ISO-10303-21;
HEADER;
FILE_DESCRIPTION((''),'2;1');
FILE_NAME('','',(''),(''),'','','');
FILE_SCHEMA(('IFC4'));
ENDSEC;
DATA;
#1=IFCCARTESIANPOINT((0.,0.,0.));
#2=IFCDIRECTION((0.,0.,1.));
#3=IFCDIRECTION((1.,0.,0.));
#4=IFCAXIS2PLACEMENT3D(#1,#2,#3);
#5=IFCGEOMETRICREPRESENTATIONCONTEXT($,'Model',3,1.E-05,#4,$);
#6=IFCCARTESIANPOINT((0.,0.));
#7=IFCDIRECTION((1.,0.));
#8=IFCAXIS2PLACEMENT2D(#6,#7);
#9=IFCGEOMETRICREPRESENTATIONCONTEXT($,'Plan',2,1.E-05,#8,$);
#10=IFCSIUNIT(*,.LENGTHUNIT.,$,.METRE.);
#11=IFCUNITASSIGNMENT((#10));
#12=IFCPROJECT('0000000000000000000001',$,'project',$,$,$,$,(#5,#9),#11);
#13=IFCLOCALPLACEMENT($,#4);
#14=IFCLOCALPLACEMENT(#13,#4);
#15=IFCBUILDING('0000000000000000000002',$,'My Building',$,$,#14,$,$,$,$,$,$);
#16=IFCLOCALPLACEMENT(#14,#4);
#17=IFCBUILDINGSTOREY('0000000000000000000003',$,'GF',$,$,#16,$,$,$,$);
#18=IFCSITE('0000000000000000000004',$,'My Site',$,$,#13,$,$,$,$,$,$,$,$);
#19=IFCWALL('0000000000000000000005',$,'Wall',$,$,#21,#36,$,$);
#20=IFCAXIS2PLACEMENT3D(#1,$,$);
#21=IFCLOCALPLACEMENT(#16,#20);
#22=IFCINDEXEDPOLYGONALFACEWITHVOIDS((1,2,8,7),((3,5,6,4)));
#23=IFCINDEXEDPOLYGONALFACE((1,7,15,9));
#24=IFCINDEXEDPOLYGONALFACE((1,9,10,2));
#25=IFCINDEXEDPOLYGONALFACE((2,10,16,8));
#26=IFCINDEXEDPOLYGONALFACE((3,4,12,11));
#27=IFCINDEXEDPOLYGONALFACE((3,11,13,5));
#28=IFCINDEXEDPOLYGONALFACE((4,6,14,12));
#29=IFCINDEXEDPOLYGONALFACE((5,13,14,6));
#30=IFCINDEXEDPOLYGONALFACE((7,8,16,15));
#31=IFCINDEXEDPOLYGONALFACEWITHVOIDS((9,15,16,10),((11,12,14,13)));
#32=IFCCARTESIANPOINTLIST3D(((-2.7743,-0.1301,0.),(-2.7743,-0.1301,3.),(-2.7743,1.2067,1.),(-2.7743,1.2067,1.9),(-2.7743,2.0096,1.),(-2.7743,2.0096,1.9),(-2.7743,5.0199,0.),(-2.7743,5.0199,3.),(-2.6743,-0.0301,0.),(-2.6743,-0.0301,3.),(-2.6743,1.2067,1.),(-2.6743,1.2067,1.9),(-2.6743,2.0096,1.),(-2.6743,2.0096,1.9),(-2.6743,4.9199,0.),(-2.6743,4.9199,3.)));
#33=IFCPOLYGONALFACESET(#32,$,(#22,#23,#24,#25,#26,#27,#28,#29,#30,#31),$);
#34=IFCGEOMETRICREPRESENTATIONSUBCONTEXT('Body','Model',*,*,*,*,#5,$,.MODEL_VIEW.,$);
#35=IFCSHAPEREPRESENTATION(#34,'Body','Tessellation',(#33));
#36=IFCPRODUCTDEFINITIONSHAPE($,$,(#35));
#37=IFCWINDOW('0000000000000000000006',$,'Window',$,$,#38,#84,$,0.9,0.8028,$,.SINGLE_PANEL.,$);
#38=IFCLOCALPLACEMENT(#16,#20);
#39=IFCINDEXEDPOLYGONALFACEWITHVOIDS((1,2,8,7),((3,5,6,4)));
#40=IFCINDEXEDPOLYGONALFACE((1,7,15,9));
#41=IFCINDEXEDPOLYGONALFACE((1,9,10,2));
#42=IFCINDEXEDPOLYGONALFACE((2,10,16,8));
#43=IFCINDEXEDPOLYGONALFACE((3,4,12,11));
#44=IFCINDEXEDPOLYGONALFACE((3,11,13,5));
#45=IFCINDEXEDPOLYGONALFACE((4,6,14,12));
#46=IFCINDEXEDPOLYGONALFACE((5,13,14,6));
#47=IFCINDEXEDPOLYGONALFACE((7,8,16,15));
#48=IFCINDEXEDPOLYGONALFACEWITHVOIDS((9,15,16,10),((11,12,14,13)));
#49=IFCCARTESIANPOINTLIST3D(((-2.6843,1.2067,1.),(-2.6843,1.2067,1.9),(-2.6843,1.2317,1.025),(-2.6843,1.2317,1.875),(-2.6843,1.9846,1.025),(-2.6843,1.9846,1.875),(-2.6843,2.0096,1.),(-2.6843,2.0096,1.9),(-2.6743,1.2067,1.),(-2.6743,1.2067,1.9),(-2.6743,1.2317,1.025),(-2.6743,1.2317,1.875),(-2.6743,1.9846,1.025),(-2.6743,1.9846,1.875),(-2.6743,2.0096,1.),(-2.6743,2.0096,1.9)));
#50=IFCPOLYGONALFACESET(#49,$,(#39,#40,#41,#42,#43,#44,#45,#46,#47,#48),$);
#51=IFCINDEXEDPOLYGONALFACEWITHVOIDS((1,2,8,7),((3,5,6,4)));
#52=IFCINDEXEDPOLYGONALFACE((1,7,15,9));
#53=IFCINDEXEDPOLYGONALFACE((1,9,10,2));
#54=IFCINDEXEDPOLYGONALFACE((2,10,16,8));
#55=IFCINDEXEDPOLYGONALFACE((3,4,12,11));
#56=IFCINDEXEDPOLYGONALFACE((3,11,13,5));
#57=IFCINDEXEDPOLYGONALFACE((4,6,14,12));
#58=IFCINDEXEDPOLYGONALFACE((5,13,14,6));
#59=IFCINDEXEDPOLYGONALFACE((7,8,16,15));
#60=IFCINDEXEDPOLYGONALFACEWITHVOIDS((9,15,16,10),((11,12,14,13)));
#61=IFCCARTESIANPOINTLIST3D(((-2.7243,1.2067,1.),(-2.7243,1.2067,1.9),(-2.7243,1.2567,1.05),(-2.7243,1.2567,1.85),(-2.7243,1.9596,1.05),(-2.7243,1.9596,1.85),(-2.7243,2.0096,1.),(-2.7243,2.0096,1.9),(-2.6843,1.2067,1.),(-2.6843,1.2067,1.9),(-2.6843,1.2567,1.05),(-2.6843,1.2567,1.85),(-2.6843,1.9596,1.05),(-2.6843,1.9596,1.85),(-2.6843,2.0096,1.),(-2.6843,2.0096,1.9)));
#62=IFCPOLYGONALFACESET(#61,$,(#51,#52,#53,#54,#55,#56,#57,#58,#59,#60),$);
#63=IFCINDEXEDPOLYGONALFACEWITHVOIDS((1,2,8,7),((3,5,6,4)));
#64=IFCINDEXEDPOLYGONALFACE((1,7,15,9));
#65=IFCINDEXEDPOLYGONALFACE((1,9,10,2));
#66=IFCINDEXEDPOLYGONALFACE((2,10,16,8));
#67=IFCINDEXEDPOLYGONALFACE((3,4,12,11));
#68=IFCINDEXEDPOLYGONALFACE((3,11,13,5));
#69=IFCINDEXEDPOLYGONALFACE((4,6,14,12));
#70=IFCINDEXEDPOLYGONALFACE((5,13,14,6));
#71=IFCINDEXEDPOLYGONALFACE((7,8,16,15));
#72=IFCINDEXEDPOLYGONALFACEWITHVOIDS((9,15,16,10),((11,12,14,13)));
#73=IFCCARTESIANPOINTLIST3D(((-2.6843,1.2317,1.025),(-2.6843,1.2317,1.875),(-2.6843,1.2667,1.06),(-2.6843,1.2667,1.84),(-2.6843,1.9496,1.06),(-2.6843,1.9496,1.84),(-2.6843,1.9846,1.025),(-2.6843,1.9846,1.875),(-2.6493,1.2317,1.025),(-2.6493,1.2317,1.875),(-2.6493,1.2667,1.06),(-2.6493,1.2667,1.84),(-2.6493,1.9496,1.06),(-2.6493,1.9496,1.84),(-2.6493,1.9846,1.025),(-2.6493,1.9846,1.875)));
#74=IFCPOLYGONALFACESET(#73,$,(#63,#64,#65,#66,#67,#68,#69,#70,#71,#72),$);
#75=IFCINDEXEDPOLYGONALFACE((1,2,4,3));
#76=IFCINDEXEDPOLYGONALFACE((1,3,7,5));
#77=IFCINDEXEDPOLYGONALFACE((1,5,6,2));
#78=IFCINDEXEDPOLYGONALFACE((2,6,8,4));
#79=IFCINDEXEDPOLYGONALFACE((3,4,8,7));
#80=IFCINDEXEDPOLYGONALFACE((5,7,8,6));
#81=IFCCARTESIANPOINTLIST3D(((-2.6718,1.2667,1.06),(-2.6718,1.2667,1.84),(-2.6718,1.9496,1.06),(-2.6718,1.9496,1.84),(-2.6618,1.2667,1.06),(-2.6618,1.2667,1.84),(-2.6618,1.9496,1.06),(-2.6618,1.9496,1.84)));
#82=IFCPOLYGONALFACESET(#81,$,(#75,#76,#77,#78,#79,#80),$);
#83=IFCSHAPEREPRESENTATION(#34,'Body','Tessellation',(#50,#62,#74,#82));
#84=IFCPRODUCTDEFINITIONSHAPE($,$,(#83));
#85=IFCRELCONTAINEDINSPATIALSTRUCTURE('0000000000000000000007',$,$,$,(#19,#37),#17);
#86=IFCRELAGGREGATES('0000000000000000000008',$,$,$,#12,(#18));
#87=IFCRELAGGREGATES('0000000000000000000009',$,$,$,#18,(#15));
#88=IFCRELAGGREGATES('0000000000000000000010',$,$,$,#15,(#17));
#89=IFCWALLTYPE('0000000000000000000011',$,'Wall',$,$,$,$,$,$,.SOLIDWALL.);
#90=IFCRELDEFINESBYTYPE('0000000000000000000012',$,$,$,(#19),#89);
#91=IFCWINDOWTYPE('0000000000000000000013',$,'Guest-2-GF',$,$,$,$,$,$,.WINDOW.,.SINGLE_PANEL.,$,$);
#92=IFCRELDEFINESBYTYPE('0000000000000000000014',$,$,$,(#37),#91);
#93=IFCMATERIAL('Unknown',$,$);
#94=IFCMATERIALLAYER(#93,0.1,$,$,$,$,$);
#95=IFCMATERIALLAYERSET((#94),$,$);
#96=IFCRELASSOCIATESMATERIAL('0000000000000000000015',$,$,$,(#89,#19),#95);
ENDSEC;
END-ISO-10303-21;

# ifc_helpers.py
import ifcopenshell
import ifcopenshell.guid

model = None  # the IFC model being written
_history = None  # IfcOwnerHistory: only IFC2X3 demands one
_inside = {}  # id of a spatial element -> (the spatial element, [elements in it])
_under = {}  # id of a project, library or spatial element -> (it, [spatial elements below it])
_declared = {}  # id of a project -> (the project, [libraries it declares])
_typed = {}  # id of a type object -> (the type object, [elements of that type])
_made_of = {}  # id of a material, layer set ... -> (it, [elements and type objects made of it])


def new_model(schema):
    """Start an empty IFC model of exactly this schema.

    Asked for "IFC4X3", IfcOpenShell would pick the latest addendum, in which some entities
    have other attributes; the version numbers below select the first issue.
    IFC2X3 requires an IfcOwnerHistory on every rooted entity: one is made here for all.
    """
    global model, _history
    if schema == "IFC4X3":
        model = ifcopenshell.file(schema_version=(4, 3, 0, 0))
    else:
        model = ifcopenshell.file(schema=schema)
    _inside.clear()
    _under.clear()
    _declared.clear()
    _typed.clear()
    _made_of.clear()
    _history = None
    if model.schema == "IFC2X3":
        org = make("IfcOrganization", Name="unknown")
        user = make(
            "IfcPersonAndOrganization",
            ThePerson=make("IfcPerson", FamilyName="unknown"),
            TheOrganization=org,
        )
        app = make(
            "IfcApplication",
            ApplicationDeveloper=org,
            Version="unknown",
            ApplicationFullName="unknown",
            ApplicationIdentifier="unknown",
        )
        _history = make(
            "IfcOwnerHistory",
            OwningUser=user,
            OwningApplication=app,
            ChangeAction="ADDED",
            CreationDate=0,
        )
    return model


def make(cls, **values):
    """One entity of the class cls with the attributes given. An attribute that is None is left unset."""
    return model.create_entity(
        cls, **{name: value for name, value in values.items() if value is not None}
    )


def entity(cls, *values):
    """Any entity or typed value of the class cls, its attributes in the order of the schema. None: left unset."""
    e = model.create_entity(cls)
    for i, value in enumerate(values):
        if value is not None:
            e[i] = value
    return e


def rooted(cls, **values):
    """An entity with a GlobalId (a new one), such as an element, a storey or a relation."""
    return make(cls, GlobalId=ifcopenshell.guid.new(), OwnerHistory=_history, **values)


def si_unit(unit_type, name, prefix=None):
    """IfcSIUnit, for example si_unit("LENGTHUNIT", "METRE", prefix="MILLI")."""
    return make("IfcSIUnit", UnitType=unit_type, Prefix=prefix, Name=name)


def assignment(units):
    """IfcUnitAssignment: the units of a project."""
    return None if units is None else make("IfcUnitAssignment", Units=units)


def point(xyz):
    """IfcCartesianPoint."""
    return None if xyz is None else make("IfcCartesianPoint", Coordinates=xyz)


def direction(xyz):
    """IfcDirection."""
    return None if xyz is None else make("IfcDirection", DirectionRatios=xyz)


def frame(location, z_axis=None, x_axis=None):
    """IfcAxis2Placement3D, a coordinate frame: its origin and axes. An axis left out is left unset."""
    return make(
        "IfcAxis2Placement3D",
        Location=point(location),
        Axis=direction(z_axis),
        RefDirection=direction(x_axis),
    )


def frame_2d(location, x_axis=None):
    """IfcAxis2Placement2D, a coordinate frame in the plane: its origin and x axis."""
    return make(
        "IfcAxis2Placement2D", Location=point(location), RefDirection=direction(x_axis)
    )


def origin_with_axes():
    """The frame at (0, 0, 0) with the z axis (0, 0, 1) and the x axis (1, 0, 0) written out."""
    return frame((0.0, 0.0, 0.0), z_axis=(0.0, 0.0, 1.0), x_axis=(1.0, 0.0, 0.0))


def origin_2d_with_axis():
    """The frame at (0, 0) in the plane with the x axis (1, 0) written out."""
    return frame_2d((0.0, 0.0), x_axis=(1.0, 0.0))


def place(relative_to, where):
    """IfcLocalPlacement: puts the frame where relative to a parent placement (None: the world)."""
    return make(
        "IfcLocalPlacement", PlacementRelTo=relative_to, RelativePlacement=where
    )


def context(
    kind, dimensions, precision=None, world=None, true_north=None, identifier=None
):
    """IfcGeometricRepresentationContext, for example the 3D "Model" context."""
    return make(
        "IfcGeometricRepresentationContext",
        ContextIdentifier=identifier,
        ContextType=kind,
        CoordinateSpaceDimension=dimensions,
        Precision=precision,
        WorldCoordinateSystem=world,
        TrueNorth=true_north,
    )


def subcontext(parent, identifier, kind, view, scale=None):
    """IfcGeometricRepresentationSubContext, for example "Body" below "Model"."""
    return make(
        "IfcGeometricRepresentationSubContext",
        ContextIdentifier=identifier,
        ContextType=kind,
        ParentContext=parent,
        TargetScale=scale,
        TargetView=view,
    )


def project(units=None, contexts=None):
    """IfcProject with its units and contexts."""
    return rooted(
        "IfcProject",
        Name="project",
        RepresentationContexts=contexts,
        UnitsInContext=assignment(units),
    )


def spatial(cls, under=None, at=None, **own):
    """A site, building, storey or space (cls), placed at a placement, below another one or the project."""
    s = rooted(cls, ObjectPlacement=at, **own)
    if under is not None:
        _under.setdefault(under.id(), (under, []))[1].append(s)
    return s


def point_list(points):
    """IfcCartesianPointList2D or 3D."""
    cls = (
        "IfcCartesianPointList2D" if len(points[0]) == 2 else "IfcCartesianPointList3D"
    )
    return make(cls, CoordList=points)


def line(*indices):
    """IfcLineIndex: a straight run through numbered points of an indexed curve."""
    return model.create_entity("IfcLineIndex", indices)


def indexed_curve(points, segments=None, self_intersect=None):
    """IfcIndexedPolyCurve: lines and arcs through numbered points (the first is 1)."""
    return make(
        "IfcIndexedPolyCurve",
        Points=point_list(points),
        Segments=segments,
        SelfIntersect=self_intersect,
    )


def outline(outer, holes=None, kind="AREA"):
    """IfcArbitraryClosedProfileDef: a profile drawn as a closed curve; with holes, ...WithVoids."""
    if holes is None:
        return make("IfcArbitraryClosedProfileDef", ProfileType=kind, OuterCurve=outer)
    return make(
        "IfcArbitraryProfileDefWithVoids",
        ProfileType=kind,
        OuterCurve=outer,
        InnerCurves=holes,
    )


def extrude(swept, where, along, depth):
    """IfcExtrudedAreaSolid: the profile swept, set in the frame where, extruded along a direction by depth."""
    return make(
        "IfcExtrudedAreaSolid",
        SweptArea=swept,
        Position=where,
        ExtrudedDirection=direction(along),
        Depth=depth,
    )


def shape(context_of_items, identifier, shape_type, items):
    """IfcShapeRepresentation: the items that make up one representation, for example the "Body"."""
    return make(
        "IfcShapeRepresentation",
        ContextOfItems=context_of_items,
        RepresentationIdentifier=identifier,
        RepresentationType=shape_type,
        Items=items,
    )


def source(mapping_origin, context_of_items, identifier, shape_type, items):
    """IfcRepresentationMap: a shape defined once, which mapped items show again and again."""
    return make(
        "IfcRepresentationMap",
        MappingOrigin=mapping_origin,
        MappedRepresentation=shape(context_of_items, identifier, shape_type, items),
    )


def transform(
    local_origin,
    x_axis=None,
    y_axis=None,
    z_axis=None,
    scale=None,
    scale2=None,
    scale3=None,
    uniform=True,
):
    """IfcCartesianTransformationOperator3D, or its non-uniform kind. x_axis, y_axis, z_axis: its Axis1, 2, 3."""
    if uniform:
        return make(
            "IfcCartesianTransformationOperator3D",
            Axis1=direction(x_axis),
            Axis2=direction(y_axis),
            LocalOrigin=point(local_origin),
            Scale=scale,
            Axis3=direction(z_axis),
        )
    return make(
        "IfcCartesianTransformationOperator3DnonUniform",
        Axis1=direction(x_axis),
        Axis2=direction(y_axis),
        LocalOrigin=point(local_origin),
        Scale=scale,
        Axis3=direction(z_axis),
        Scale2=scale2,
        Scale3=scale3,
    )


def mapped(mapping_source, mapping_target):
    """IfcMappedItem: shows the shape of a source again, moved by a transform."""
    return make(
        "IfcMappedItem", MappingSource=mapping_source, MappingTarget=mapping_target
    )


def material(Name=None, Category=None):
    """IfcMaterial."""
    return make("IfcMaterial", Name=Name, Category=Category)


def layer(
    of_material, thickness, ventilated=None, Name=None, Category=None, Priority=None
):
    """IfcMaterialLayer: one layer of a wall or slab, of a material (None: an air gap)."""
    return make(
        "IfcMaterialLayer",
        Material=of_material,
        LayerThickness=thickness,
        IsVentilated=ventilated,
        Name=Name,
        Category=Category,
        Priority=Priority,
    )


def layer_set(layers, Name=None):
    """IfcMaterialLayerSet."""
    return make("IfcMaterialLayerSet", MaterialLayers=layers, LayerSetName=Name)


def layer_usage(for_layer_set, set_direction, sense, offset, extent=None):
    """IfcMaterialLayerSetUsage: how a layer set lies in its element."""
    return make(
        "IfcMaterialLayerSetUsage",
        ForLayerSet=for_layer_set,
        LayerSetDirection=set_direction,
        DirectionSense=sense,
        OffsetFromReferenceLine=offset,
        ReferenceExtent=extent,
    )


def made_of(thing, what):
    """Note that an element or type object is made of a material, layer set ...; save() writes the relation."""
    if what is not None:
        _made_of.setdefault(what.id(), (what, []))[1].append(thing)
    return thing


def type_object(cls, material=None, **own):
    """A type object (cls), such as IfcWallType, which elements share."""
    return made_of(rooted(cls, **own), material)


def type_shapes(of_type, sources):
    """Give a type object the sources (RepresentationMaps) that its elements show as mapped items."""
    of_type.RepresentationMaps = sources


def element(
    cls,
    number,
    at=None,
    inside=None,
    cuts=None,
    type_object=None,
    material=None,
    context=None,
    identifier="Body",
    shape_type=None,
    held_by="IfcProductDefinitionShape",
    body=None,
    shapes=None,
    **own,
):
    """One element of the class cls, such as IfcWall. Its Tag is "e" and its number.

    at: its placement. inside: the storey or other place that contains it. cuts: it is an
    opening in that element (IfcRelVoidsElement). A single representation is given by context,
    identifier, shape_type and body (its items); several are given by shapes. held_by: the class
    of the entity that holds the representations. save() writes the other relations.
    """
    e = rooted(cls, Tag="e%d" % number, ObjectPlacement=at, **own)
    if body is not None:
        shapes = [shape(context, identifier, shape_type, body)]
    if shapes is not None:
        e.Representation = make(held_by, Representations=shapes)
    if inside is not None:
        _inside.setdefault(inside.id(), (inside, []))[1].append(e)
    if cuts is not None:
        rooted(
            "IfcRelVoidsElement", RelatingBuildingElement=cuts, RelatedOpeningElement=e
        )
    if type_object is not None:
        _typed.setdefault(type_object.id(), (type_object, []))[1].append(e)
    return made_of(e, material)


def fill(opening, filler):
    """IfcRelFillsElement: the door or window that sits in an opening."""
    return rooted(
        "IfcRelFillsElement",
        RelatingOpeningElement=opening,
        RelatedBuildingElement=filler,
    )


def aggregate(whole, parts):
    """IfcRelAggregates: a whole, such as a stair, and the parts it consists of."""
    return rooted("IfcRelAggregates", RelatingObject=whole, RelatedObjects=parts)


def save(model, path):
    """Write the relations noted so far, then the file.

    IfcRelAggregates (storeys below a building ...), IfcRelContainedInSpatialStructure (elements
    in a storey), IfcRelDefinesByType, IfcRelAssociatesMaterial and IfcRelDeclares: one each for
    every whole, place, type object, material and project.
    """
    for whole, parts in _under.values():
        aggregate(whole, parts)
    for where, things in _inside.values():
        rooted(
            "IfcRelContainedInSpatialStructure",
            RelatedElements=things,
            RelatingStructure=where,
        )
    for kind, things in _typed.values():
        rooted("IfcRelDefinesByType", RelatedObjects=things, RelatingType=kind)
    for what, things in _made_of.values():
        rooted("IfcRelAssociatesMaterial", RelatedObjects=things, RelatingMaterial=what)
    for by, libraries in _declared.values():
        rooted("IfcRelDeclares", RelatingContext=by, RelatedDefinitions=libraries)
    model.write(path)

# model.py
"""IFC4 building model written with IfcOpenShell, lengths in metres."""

from ifc_helpers import new_model, entity, si_unit, frame, origin_with_axes, origin_2d_with_axis, place, context, subcontext, project, spatial, line, indexed_curve, outline, extrude, shape, source, transform, mapped, material, layer, layer_set, layer_usage, type_object, type_shapes, element, fill, save


model = new_model("IFC4")

# Units and contexts
model_context = context("Model", 3, precision=1e-05, world=origin_with_axes())
plan_context = context("Plan", 2, precision=1e-05, world=origin_2d_with_axis())
body_context_1 = subcontext(model_context, "Body", "Model", "MODEL_VIEW")
body_context_2 = subcontext(plan_context, "Body", "Plan", "PLAN_VIEW")
ifc_project = project(units=[si_unit("LENGTHUNIT", "METRE")], contexts=[model_context, plan_context])

# Site, building, storey
site_placement = place(None, origin_with_axes())
site = spatial("IfcSite", under=ifc_project, at=site_placement, Name="My Site")
building_placement = place(site_placement, origin_with_axes())
building = spatial("IfcBuilding", under=site, at=building_placement, Name="My Building")
storey_placement = place(building_placement, origin_with_axes())
storey = spatial("IfcBuildingStorey", under=building, at=storey_placement, Name="GF")

# Shared definitions
ifc_material = material(Name="Unknown")

# Shared definitions
ifc_layer_1 = layer(ifc_material, 0.1)
ifc_layer_set_1 = layer_set([ifc_layer_1])
wall_type = type_object("IfcWallType", Name="Wall", PredefinedType="SOLIDWALL", material=ifc_layer_set_1)

# Wall, opening, window
ifc_layer_usage_1 = layer_usage(ifc_layer_set_1, "AXIS2", "POSITIVE", 0.0)
wall_1_placement = place(storey_placement, frame((-2.7743, 5.0199, 0.0), z_axis=(0.0, 0.0, 1.0), x_axis=(0.0, -1.0, 0.0)))
wall_1 = element("IfcWall", 1, at=wall_1_placement, inside=storey, type_object=wall_type, material=ifc_layer_usage_1, Name="Wall", context=body_context_1, shape_type="SweptSolid", body=[
    extrude(outline(indexed_curve([(0.0, 0.0), (0.1, 0.1), (5.05, 0.1), (5.15, 0.0)], segments=[line(1, 2, 3, 4, 1)])), origin_with_axes(), (0.0, 0.0, 1.0), 3.0),
])
shared_shape_1 = source(origin_with_axes(), body_context_1, "Body", "SweptSolid", [
    extrude(outline(indexed_curve([(0.0, 0.0), (0.8028, 0.0), (0.8028, 0.9), (0.0, 0.9)], segments=[line(1, 2, 3, 4, 1)])), frame((0.0, -0.6, 0.0), z_axis=(0.0, -1.0, 0.0), x_axis=(1.0, 0.0, 0.0)), (0.0, 0.0, -1.0), 1.2),
])
opening_1_placement = place(wall_1_placement, frame((3.0103, 0.0, 1.0), z_axis=(0.0, 0.0, 1.0), x_axis=(1.0, 0.0, 0.0)))
opening_1 = element("IfcOpeningElement", 2, at=opening_1_placement, cuts=wall_1, PredefinedType="OPENING", context=body_context_1, shape_type="MappedRepresentation", body=[
    mapped(shared_shape_1, transform((0.0, 0.0, 0.0), x_axis=(1.0, 0.0, 0.0), y_axis=(0.0, 1.0, 0.0), z_axis=(0.0, 0.0, 1.0), scale=1.0)),
])
window_type_1 = type_object("IfcWindowType", Name="Guest-2-GF", PartitioningType="SINGLE_PANEL", PredefinedType="WINDOW")
shared_shape_2 = source(origin_with_axes(), body_context_1, "Body", "SweptSolid", [
    extrude(outline(indexed_curve([(0.0, 0.0), (0.8028, 0.0), (0.8028, 0.9), (0.0, 0.9)], segments=[line(1, 2, 3, 4, 1)]), holes=[indexed_curve([(0.025, 0.025), (0.7778, 0.025), (0.7778, 0.875), (0.025, 0.875)], segments=[line(1, 2, 3, 4, 1)])]), frame((0.0, 0.09, 0.0), z_axis=(0.0, -1.0, 0.0), x_axis=(1.0, 0.0, 0.0)), (0.0, 0.0, -1.0), 0.01),
    extrude(outline(indexed_curve([(0.0, 0.0), (0.8028, 0.0), (0.8028, 0.9), (0.0, 0.9)], segments=[line(1, 2, 3, 4, 1)]), holes=[indexed_curve([(0.05, 0.05), (0.7528, 0.05), (0.7528, 0.85), (0.05, 0.85)], segments=[line(1, 2, 3, 4, 1)])]), frame((0.0, 0.05, 0.0), z_axis=(0.0, -1.0, 0.0), x_axis=(1.0, 0.0, 0.0)), (0.0, 0.0, -1.0), 0.04),
    extrude(outline(indexed_curve([(0.0, 0.0), (0.7528, 0.0), (0.7528, 0.85), (0.0, 0.85)], segments=[line(1, 2, 3, 4, 1)]), holes=[indexed_curve([(0.035, 0.035), (0.7178, 0.035), (0.7178, 0.815), (0.035, 0.815)], segments=[line(1, 2, 3, 4, 1)])]), frame((0.025, 0.09, 0.025), z_axis=(0.0, -1.0, 0.0), x_axis=(1.0, 0.0, 0.0)), (0.0, 0.0, -1.0), 0.035),
    extrude(outline(indexed_curve([(0.035, 0.035), (0.7178, 0.035), (0.7178, 0.815), (0.035, 0.815)], segments=[line(1, 2, 3, 4, 1)])), frame((0.025, 0.1025, 0.025), z_axis=(0.0, -1.0, 0.0), x_axis=(1.0, 0.0, 0.0)), (0.0, 0.0, -1.0), 0.01),
])
shared_shape_3 = source(origin_with_axes(), body_context_2, "Body", "Curve2D", [
    entity("IfcIndexedPolyCurve", entity("IfcCartesianPointList2D", [[0.05, 0.05], [0.7528, 0.05]])),
    entity("IfcIndexedPolyCurve", entity("IfcCartesianPointList2D", [[0.0, 0.1], [0.025, 0.1], [0.025, 0.09], [0.05, 0.09], [0.05, 0.05], [0.0, 0.05]]), [entity("IfcLineIndex", [1, 2, 3, 4, 5, 6, 1])]),
    entity("IfcIndexedPolyCurve", entity("IfcCartesianPointList2D", [[0.8028, 0.1], [0.7778, 0.1], [0.7778, 0.09], [0.7528, 0.09], [0.7528, 0.05], [0.8028, 0.05]]), [entity("IfcLineIndex", [1, 2, 3, 4, 5, 6, 1])]),
    entity("IfcIndexedPolyCurve", entity("IfcCartesianPointList2D", [[0.025, 0.09], [0.06, 0.09], [0.06, 0.125], [0.025, 0.125]]), [entity("IfcLineIndex", [1, 2, 3, 4, 1])]),
    entity("IfcIndexedPolyCurve", entity("IfcCartesianPointList2D", [[0.7778, 0.09], [0.7428, 0.09], [0.7428, 0.125], [0.7778, 0.125]]), [entity("IfcLineIndex", [1, 2, 3, 4, 1])]),
    entity("IfcIndexedPolyCurve", entity("IfcCartesianPointList2D", [[0.06, 0.09], [0.7428, 0.09]])),
    entity("IfcIndexedPolyCurve", entity("IfcCartesianPointList2D", [[0.06, 0.125], [0.7428, 0.125]])),
    entity("IfcIndexedPolyCurve", entity("IfcCartesianPointList2D", [[0.06, 0.1075], [0.7428, 0.1075]])),
])
type_shapes(window_type_1, [shared_shape_2, shared_shape_3])
window_1_placement = place(opening_1_placement, frame((0.0, 0.0, 0.0), z_axis=(0.0, 0.0, 1.0), x_axis=(1.0, 0.0, 0.0)))
window_1 = element("IfcWindow", 3, at=window_1_placement, inside=storey, type_object=window_type_1, Name="Window", OverallHeight=0.9, OverallWidth=0.8028, PartitioningType="SINGLE_PANEL", shapes=[
    shape(body_context_1, "Body", "MappedRepresentation", [mapped(shared_shape_2, transform((0.0, 0.0, 0.0), x_axis=(1.0, 0.0, 0.0), y_axis=(0.0, 1.0, 0.0), z_axis=(0.0, 0.0, 1.0), scale=1.0))]),
    shape(body_context_2, "Body", "MappedRepresentation", [mapped(shared_shape_3, transform((0.0, 0.0, 0.0), x_axis=(1.0, 0.0, 0.0), y_axis=(0.0, 1.0, 0.0), z_axis=(0.0, 0.0, 1.0), scale=1.0))]),
])
fill(opening_1, window_1)

save(model, "model.ifc")
